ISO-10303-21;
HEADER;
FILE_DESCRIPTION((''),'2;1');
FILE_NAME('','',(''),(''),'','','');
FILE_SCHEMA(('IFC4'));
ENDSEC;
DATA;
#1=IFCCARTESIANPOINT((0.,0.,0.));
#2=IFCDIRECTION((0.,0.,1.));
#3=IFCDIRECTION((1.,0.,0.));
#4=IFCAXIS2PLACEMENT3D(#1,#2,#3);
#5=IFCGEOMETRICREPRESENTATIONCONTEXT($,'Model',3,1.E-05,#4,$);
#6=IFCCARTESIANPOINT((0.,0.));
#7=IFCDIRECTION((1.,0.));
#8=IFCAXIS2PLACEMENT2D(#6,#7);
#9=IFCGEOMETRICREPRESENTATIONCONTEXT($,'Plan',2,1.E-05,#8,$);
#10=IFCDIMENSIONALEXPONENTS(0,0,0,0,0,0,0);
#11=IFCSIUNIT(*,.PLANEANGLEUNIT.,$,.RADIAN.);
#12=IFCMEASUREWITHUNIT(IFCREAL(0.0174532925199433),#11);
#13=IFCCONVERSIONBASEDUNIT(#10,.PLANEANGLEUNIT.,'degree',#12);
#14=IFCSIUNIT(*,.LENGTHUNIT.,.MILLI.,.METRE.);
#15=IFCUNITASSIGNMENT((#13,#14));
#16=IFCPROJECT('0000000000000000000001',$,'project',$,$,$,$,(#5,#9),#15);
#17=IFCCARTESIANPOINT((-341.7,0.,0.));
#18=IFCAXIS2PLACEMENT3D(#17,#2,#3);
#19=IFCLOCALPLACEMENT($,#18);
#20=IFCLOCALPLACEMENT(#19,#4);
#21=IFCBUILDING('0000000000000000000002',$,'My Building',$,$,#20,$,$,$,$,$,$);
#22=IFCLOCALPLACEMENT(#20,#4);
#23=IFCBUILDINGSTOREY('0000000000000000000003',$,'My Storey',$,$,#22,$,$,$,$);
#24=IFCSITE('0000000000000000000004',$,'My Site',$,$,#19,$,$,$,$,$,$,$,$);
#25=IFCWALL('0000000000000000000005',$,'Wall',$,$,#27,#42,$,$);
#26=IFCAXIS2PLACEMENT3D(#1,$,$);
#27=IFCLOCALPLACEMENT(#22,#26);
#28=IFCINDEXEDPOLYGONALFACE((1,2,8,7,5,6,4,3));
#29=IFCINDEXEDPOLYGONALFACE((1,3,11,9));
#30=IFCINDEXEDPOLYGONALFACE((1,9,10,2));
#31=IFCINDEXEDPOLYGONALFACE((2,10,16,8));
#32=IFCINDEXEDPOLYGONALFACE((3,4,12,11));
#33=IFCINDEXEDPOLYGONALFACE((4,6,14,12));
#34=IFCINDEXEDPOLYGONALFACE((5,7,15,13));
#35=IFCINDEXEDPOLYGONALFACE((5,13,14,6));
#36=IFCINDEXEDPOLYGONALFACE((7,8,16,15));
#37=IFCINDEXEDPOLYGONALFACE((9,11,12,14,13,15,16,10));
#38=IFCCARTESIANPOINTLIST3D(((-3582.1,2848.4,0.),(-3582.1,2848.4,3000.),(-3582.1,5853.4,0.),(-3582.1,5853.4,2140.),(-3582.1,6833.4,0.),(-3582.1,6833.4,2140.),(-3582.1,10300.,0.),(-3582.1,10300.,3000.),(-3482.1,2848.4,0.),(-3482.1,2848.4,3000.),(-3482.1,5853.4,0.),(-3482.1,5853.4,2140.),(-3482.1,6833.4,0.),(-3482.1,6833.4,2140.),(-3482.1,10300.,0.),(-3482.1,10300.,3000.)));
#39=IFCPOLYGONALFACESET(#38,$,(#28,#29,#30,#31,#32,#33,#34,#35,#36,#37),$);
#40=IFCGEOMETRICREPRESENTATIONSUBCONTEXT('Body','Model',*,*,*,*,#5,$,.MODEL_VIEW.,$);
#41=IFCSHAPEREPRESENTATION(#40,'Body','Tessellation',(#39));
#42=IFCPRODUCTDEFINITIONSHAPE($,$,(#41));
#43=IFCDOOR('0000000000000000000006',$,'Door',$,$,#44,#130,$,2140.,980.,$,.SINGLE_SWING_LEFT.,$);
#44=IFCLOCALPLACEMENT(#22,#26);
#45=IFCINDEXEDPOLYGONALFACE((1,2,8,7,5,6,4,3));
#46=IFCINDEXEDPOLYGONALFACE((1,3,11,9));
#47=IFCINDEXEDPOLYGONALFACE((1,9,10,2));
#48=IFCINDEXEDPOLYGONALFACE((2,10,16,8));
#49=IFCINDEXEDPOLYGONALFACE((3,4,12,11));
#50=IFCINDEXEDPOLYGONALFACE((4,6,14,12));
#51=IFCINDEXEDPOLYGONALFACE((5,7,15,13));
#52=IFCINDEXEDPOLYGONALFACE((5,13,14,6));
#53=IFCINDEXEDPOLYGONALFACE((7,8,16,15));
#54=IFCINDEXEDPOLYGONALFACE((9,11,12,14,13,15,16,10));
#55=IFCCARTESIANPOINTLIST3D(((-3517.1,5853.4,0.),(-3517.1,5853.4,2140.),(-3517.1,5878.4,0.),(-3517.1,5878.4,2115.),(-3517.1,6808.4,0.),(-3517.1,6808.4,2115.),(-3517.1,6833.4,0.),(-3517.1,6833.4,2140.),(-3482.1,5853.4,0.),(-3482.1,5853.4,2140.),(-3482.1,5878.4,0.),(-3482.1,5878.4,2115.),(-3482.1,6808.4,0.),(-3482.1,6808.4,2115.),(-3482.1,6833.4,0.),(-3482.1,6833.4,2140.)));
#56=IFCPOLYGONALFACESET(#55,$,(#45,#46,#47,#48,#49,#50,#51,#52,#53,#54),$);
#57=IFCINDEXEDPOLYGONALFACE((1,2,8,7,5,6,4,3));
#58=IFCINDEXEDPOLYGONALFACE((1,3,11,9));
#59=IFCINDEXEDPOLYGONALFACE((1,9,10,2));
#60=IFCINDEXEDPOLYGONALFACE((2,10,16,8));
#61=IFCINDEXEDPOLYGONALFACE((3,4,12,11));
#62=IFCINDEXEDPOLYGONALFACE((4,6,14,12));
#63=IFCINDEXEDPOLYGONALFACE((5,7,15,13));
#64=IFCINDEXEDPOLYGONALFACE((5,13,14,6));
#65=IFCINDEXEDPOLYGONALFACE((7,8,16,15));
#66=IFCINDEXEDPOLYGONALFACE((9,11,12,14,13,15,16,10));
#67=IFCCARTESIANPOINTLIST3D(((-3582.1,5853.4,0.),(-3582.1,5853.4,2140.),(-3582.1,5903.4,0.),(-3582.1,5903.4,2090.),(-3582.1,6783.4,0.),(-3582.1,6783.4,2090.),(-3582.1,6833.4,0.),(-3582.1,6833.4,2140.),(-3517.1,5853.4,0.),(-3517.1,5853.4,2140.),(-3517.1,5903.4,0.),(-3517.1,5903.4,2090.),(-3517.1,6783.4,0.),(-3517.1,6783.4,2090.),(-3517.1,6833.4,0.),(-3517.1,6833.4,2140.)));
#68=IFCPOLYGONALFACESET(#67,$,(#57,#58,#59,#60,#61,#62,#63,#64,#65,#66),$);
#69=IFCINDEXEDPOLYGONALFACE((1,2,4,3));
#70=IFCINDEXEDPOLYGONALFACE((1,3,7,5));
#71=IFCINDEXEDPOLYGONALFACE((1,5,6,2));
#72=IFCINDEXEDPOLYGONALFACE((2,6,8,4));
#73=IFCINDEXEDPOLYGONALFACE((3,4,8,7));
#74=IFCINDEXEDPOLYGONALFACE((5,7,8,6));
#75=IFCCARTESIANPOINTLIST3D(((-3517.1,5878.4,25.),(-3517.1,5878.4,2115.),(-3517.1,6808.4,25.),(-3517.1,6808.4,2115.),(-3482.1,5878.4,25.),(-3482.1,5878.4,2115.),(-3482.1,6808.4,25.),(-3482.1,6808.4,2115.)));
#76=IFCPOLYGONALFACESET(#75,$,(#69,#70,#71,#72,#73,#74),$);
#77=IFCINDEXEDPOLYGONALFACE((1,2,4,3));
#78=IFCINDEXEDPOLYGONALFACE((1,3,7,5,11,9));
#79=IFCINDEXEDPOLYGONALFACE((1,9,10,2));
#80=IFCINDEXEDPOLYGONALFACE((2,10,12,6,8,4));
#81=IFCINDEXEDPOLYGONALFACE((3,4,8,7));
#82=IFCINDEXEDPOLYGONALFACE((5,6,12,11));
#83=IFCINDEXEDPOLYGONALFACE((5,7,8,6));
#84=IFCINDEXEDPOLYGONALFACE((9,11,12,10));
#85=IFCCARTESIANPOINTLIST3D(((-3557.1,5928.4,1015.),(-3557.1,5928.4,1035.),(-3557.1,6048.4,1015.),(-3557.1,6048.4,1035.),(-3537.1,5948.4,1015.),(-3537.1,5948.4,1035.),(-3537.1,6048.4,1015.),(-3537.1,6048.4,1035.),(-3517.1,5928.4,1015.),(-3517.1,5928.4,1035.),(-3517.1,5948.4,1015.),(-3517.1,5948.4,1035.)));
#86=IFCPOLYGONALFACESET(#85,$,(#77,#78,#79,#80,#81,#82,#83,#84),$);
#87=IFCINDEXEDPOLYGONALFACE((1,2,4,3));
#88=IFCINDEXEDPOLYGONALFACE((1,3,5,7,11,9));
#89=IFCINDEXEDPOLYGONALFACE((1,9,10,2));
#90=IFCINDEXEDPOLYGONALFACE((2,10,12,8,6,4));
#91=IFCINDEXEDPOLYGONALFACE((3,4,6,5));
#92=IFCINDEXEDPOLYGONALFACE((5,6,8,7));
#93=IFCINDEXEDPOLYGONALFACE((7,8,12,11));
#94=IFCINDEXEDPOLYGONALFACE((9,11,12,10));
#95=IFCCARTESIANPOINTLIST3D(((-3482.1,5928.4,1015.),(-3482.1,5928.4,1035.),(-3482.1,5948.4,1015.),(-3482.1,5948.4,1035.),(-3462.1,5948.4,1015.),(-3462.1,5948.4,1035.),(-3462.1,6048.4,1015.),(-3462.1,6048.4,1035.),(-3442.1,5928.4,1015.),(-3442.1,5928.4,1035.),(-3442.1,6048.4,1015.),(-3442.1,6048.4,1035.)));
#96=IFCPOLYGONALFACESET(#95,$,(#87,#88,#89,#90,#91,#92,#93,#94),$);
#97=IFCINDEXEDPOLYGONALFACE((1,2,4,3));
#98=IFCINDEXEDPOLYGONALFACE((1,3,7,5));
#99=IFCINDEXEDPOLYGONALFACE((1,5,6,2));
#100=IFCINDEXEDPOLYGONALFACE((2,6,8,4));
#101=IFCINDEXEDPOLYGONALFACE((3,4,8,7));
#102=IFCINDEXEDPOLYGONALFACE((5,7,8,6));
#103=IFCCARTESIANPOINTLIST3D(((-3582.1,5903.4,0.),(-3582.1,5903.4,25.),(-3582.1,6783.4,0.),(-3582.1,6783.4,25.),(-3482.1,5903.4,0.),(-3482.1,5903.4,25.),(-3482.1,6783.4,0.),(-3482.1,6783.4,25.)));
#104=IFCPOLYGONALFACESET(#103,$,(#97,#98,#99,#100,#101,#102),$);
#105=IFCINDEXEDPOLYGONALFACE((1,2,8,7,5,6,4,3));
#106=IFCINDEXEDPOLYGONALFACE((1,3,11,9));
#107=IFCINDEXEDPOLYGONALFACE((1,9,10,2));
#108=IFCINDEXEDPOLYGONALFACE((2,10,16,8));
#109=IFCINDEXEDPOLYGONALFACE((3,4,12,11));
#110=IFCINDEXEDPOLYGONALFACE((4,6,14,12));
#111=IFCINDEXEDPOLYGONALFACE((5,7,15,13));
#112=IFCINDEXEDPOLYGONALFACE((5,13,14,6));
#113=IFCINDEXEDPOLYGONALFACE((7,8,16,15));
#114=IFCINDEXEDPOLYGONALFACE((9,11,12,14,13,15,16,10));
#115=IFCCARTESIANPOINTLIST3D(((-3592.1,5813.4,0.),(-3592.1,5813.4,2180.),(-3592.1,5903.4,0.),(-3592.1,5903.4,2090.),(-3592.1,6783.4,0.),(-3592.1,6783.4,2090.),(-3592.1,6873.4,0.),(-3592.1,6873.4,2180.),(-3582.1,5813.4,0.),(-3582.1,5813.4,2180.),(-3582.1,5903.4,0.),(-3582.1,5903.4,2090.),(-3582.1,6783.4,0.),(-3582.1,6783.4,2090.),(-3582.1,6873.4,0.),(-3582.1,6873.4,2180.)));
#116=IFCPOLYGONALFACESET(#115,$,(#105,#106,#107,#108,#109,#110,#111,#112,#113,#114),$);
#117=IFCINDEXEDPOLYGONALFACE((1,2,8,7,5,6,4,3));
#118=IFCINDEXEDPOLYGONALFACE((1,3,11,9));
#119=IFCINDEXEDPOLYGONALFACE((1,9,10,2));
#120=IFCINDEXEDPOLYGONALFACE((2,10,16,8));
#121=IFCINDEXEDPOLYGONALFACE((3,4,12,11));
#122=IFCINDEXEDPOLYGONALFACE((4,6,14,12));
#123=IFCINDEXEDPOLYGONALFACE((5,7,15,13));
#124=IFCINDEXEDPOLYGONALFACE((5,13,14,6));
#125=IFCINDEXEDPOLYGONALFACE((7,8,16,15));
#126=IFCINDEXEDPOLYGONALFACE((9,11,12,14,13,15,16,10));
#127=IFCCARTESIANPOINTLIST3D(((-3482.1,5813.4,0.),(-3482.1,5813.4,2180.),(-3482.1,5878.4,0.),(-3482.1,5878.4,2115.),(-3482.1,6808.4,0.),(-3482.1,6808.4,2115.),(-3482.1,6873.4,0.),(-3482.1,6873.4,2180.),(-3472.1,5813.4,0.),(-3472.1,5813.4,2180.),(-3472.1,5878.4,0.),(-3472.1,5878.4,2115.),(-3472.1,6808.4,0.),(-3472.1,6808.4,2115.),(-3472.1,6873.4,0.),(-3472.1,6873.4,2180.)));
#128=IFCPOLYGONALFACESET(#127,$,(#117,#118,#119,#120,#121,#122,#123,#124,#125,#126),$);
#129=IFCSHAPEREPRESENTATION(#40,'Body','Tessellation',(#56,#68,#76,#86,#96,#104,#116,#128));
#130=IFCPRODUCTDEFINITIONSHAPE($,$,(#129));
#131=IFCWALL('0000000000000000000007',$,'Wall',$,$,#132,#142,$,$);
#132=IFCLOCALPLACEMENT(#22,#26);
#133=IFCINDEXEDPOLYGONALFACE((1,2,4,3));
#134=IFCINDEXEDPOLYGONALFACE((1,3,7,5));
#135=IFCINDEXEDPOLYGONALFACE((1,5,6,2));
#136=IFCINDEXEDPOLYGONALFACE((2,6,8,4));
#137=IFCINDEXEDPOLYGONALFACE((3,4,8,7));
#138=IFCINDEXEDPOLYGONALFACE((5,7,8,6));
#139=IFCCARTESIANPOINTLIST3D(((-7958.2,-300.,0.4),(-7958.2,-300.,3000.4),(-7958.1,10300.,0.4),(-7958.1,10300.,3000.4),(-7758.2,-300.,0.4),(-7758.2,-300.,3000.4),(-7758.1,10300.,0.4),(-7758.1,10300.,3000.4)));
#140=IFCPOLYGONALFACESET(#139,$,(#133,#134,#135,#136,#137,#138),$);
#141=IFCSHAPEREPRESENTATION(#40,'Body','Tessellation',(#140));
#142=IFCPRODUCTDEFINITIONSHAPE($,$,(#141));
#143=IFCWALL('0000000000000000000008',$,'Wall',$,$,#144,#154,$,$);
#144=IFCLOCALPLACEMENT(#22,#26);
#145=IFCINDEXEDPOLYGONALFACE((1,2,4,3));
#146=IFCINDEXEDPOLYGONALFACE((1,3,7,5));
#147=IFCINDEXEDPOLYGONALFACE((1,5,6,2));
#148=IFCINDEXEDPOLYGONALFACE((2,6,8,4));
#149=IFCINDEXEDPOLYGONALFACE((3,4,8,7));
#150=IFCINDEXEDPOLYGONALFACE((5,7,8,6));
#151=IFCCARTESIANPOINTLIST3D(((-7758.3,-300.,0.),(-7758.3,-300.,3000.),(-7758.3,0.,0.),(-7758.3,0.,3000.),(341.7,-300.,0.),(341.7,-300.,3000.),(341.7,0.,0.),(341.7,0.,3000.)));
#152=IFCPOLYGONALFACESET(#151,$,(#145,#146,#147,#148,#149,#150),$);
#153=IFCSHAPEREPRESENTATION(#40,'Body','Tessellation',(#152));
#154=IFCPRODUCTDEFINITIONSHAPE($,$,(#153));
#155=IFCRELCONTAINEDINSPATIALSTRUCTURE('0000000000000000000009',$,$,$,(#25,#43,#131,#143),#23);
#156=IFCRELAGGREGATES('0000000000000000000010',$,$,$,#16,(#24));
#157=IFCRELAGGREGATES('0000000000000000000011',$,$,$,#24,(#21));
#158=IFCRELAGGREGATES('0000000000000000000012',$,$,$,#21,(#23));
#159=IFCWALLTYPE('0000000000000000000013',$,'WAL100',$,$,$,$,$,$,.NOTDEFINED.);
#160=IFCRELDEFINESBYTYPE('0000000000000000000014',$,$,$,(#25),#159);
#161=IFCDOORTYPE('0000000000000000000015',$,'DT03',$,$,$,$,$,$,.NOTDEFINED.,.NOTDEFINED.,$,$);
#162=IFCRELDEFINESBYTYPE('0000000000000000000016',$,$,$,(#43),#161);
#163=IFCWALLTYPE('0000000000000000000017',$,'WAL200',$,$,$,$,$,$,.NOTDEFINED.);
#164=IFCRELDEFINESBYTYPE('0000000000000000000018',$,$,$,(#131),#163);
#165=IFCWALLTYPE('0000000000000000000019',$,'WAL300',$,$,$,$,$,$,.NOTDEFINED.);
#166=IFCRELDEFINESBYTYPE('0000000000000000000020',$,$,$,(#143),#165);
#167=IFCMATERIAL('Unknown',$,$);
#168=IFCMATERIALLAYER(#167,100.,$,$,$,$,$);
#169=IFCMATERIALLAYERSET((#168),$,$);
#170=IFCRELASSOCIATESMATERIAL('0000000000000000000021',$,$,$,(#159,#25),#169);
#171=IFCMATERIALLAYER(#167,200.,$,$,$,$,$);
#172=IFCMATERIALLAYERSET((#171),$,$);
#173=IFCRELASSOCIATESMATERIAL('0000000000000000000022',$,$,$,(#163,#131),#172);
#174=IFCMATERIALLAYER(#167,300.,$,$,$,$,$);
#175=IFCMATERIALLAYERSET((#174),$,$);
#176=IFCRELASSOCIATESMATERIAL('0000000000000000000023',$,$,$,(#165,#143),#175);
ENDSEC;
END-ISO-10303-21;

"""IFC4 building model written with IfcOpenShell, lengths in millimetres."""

from ifc_helpers import new_model, entity, si_unit, converted_unit, frame, origin_with_axes, origin_2d_with_axis, place, context, subcontext, project, spatial, line, indexed_curve, outline, extrude, shape, source, transform, mapped, material, layer, layer_set, layer_usage, type_object, type_shapes, element, fill, save


model = new_model("IFC4")

# Units and contexts
model_context = context("Model", 3, precision=1e-05, world=origin_with_axes())
plan_context = context("Plan", 2, precision=1e-05, world=origin_2d_with_axis())
body_context_1 = subcontext(model_context, "Body", "Model", "MODEL_VIEW")
body_context_2 = subcontext(plan_context, "Body", "Plan", "PLAN_VIEW")
ifc_project = project(units=[converted_unit("PLANEANGLEUNIT", "degree", entity("IfcReal", 0.0174532925199433), si_unit("PLANEANGLEUNIT", "RADIAN"), dimensions=[0, 0, 0, 0, 0, 0, 0]), si_unit("LENGTHUNIT", "METRE", prefix="MILLI")], contexts=[model_context, plan_context])

# Site, building, storey
site_placement = place(None, frame((-341.7, 0.0, 0.0), z_axis=(0.0, 0.0, 1.0), x_axis=(1.0, 0.0, 0.0)))
site = spatial("IfcSite", under=ifc_project, at=site_placement, Name="My Site")
building_placement = place(site_placement, origin_with_axes())
building = spatial("IfcBuilding", under=site, at=building_placement, Name="My Building")
storey_placement = place(building_placement, origin_with_axes())
storey = spatial("IfcBuildingStorey", under=building, at=storey_placement, Name="My Storey")

# Shared definitions
ifc_material = material(Name="Unknown")
ifc_layer_1 = layer(ifc_material, 100.0)
ifc_layer_set_1 = layer_set([ifc_layer_1])
wall_type_1 = type_object("IfcWallType", Name="WAL100", PredefinedType="NOTDEFINED", material=ifc_layer_set_1)

# Wall, opening, door
ifc_layer_usage_1 = layer_usage(ifc_layer_set_1, "AXIS2", "POSITIVE", 0.0)
wall_1_placement = place(storey_placement, frame((-3482.1, 2848.4, 0.0), z_axis=(0.0, 0.0, 1.0), x_axis=(0.0, 1.0, 0.0)))
wall_1 = element("IfcWall", 1, at=wall_1_placement, inside=storey, type_object=wall_type_1, material=ifc_layer_usage_1, Name="Wall", context=body_context_1, shape_type="SweptSolid", body=[
    extrude(outline(indexed_curve([(0.0, 0.0), (0.0, 100.0), (7451.6, 100.0), (7451.6, 0.0), (0.0, 0.0)], self_intersect=False)), origin_with_axes(), (0.0, 0.0, 1.0), 3000.0),
])
shared_shape_1 = source(origin_with_axes(), body_context_1, "Body", "SweptSolid", [
    extrude(outline(indexed_curve([(0.0, 0.0), (980.0, 0.0), (980.0, 2140.0), (0.0, 2140.0)], segments=[line(1, 2, 3, 4, 1)])), frame((0.0, -100.0, 0.0), z_axis=(0.0, -1.0, 0.0), x_axis=(1.0, 0.0, 0.0)), (0.0, 0.0, -1.0), 300.0),
])
opening_1_placement = place(wall_1_placement, frame((3984.9, 100.0, 0.0), z_axis=(0.0, 0.0, 1.0), x_axis=(-1.0, 0.0, 0.0)))
opening_1 = element("IfcOpeningElement", 2, at=opening_1_placement, cuts=wall_1, PredefinedType="OPENING", context=body_context_1, shape_type="MappedRepresentation", body=[
    mapped(shared_shape_1, transform((0.0, 0.0, 0.0), x_axis=(1.0, 0.0, 0.0), y_axis=(0.0, 1.0, 0.0), z_axis=(0.0, 0.0, 1.0), scale=1.0)),
])
door_type_1 = type_object("IfcDoorType", Name="DT03", OperationType="NOTDEFINED", PredefinedType="NOTDEFINED")
shared_shape_2 = source(origin_with_axes(), body_context_1, "Body", "SweptSolid", [
    extrude(outline(indexed_curve([(0.0, 0.0), (0.0, 2140.0), (980.0, 2140.0), (980.0, 0.0), (955.0, 0.0), (955.0, 2115.0), (25.0, 2115.0), (25.0, 0.0)], segments=[line(1, 2, 3, 4, 5, 6, 7, 8, 1)])), frame((0.0, 65.0, 0.0), z_axis=(0.0, -1.0, 0.0), x_axis=(1.0, 0.0, 0.0)), (0.0, 0.0, -1.0), 35.0),
    extrude(outline(indexed_curve([(0.0, 0.0), (0.0, 2140.0), (980.0, 2140.0), (980.0, 0.0), (930.0, 0.0), (930.0, 2090.0), (50.0, 2090.0), (50.0, 0.0)], segments=[line(1, 2, 3, 4, 5, 6, 7, 8, 1)])), frame((0.0, 0.0, 0.0), z_axis=(0.0, -1.0, 0.0), x_axis=(1.0, 0.0, 0.0)), (0.0, 0.0, -1.0), 65.0),
    extrude(outline(indexed_curve([(0.0, 0.0), (930.0, 0.0), (930.0, 35.0), (0.0, 35.0)], segments=[line(1, 2, 3, 4, 1)])), frame((25.0, 65.0, 25.0), z_axis=(0.0, 0.0, 1.0), x_axis=(1.0, 0.0, 0.0)), (0.0, 0.0, 1.0), 2090.0),
    extrude(outline(indexed_curve([(0.0, 0.0), (0.0, -40.0), (-120.0, -40.0), (-120.0, -20.0), (-20.0, -20.0), (-20.0, 0.0)], segments=[line(1, 2, 3, 4, 5, 6, 1)])), frame((905.0, 65.0, 1015.0), z_axis=(0.0, 0.0, 1.0), x_axis=(1.0, 0.0, 0.0)), (0.0, 0.0, 1.0), 20.0),
    extrude(outline(indexed_curve([(0.0, 0.0), (0.0, 40.0), (-120.0, 40.0), (-120.0, 20.0), (-20.0, 20.0), (-20.0, 0.0)], segments=[line(1, 2, 3, 4, 5, 6, 1)])), frame((905.0, 100.0, 1015.0), z_axis=(0.0, 0.0, 1.0), x_axis=(1.0, 0.0, 0.0)), (0.0, 0.0, 1.0), 20.0),
    extrude(outline(indexed_curve([(0.0, 0.0), (880.0, 0.0), (880.0, 100.0), (0.0, 100.0)], segments=[line(1, 2, 3, 4, 1)])), frame((50.0, 0.0, 0.0), z_axis=(0.0, 0.0, 1.0), x_axis=(1.0, 0.0, 0.0)), (0.0, 0.0, 1.0), 25.0),
    extrude(outline(indexed_curve([(0.0, 0.0), (0.0, 2180.0), (1060.0, 2180.0), (1060.0, 0.0), (970.0, 0.0), (970.0, 2090.0), (90.0, 2090.0), (90.0, 0.0)], segments=[line(1, 2, 3, 4, 5, 6, 7, 8, 1)])), frame((-40.0, -10.0, 0.0), z_axis=(0.0, -1.0, 0.0), x_axis=(1.0, 0.0, 0.0)), (0.0, 0.0, -1.0), 10.0),
    extrude(outline(indexed_curve([(0.0, 0.0), (0.0, 2180.0), (1060.0, 2180.0), (1060.0, 0.0), (995.0, 0.0), (995.0, 2115.0), (65.0, 2115.0), (65.0, 0.0)], segments=[line(1, 2, 3, 4, 5, 6, 7, 8, 1)])), frame((-40.0, 100.0, 0.0), z_axis=(0.0, -1.0, 0.0), x_axis=(1.0, 0.0, 0.0)), (0.0, 0.0, -1.0), 10.0),
])
shared_shape_3 = source(origin_with_axes(), body_context_2, "Body", "Curve2D", [
    entity("IfcIndexedPolyCurve", entity("IfcCartesianPointList2D", [[0.0, 0.0], [0.0, 100.0], [25.0, 100.0], [25.0, 65.0], [50.0, 65.0], [50.0, 0.0]]), [entity("IfcLineIndex", [1, 2, 3, 4, 5, 6, 1])]),
    entity("IfcIndexedPolyCurve", entity("IfcCartesianPointList2D", [[980.0, 0.0], [980.0, 100.0], [955.0, 100.0], [955.0, 65.0], [930.0, 65.0], [930.0, 0.0]]), [entity("IfcLineIndex", [1, 2, 3, 4, 5, 6, 1])]),
    entity("IfcTrimmedCurve", entity("IfcEllipse", entity("IfcAxis2Placement2D", entity("IfcCartesianPoint", [60.0, 100.0]), entity("IfcDirection", [1.0, 0.0])), 895.0, 930.0), [entity("IfcCartesianPoint", [955.0, 100.0])], [entity("IfcCartesianPoint", [60.0, 1030.0])], True, "CARTESIAN"),
    entity("IfcIndexedPolyCurve", entity("IfcCartesianPointList2D", [[25.0, 100.0], [60.0, 100.0], [60.0, 1030.0], [25.0, 1030.0]]), [entity("IfcLineIndex", [1, 2, 3, 4, 1])]),
])
type_shapes(door_type_1, [shared_shape_2, shared_shape_3])
door_1_placement = place(opening_1_placement, frame((0.0, 0.0, 0.0), z_axis=(0.0, 0.0, 1.0), x_axis=(1.0, 0.0, 0.0)))
door_1 = element("IfcDoor", 3, at=door_1_placement, inside=storey, type_object=door_type_1, Name="Door", OperationType="SINGLE_SWING_LEFT", OverallHeight=2140.0, OverallWidth=980.0, shapes=[
    shape(body_context_1, "Body", "MappedRepresentation", [mapped(shared_shape_2, transform((0.0, 0.0, 0.0), x_axis=(1.0, 0.0, 0.0), y_axis=(0.0, 1.0, 0.0), z_axis=(0.0, 0.0, 1.0), scale=1.0))]),
    shape(body_context_2, "Body", "MappedRepresentation", [mapped(shared_shape_3, transform((0.0, 0.0, 0.0), x_axis=(1.0, 0.0, 0.0), y_axis=(0.0, 1.0, 0.0), z_axis=(0.0, 0.0, 1.0), scale=1.0))]),
])
fill(opening_1, door_1)

# Walls
ifc_layer_2 = layer(ifc_material, 200.0)
ifc_layer_set_2 = layer_set([ifc_layer_2])
ifc_layer_usage_2 = layer_usage(ifc_layer_set_2, "AXIS2", "POSITIVE", 0.0)
wall_type_2 = type_object("IfcWallType", Name="WAL200", PredefinedType="NOTDEFINED", material=ifc_layer_set_2)
wall_2_placement = place(storey_placement, frame((-7758.2, -300.0, 0.4), z_axis=(0.0, 0.0, 1.0), x_axis=(0.000002, 1.0, 0.0)))
element("IfcWall", 4, at=wall_2_placement, inside=storey, type_object=wall_type_2, material=ifc_layer_usage_2, Name="Wall", context=body_context_1, shape_type="SweptSolid", body=[
    extrude(outline(indexed_curve([(0.0, 0.0), (0.0, 200.0), (10600.0, 200.0), (10600.0, 0.0), (0.0, 0.0)], self_intersect=False)), origin_with_axes(), (0.0, 0.0, 1.0), 3000.0),
])
ifc_layer_3 = layer(ifc_material, 300.0)
ifc_layer_set_3 = layer_set([ifc_layer_3])
ifc_layer_usage_3 = layer_usage(ifc_layer_set_3, "AXIS2", "POSITIVE", 0.0)
wall_type_3 = type_object("IfcWallType", Name="WAL300", PredefinedType="NOTDEFINED", material=ifc_layer_set_3)
wall_3_placement = place(storey_placement, frame((341.7, 0.0, 0.0), z_axis=(0.0, 0.0, 1.0), x_axis=(-1.0, 0.000001, 0.0)))
element("IfcWall", 5, at=wall_3_placement, inside=storey, type_object=wall_type_3, material=ifc_layer_usage_3, Name="Wall", context=body_context_1, shape_type="SweptSolid", body=[
    extrude(outline(indexed_curve([(0.0, 0.0), (0.0, 300.0), (8100.0, 300.0), (8100.0, 0.0), (0.0, 0.0)], self_intersect=False)), origin_with_axes(), (0.0, 0.0, 1.0), 3000.0),
])

save(model, "model.ifc")
